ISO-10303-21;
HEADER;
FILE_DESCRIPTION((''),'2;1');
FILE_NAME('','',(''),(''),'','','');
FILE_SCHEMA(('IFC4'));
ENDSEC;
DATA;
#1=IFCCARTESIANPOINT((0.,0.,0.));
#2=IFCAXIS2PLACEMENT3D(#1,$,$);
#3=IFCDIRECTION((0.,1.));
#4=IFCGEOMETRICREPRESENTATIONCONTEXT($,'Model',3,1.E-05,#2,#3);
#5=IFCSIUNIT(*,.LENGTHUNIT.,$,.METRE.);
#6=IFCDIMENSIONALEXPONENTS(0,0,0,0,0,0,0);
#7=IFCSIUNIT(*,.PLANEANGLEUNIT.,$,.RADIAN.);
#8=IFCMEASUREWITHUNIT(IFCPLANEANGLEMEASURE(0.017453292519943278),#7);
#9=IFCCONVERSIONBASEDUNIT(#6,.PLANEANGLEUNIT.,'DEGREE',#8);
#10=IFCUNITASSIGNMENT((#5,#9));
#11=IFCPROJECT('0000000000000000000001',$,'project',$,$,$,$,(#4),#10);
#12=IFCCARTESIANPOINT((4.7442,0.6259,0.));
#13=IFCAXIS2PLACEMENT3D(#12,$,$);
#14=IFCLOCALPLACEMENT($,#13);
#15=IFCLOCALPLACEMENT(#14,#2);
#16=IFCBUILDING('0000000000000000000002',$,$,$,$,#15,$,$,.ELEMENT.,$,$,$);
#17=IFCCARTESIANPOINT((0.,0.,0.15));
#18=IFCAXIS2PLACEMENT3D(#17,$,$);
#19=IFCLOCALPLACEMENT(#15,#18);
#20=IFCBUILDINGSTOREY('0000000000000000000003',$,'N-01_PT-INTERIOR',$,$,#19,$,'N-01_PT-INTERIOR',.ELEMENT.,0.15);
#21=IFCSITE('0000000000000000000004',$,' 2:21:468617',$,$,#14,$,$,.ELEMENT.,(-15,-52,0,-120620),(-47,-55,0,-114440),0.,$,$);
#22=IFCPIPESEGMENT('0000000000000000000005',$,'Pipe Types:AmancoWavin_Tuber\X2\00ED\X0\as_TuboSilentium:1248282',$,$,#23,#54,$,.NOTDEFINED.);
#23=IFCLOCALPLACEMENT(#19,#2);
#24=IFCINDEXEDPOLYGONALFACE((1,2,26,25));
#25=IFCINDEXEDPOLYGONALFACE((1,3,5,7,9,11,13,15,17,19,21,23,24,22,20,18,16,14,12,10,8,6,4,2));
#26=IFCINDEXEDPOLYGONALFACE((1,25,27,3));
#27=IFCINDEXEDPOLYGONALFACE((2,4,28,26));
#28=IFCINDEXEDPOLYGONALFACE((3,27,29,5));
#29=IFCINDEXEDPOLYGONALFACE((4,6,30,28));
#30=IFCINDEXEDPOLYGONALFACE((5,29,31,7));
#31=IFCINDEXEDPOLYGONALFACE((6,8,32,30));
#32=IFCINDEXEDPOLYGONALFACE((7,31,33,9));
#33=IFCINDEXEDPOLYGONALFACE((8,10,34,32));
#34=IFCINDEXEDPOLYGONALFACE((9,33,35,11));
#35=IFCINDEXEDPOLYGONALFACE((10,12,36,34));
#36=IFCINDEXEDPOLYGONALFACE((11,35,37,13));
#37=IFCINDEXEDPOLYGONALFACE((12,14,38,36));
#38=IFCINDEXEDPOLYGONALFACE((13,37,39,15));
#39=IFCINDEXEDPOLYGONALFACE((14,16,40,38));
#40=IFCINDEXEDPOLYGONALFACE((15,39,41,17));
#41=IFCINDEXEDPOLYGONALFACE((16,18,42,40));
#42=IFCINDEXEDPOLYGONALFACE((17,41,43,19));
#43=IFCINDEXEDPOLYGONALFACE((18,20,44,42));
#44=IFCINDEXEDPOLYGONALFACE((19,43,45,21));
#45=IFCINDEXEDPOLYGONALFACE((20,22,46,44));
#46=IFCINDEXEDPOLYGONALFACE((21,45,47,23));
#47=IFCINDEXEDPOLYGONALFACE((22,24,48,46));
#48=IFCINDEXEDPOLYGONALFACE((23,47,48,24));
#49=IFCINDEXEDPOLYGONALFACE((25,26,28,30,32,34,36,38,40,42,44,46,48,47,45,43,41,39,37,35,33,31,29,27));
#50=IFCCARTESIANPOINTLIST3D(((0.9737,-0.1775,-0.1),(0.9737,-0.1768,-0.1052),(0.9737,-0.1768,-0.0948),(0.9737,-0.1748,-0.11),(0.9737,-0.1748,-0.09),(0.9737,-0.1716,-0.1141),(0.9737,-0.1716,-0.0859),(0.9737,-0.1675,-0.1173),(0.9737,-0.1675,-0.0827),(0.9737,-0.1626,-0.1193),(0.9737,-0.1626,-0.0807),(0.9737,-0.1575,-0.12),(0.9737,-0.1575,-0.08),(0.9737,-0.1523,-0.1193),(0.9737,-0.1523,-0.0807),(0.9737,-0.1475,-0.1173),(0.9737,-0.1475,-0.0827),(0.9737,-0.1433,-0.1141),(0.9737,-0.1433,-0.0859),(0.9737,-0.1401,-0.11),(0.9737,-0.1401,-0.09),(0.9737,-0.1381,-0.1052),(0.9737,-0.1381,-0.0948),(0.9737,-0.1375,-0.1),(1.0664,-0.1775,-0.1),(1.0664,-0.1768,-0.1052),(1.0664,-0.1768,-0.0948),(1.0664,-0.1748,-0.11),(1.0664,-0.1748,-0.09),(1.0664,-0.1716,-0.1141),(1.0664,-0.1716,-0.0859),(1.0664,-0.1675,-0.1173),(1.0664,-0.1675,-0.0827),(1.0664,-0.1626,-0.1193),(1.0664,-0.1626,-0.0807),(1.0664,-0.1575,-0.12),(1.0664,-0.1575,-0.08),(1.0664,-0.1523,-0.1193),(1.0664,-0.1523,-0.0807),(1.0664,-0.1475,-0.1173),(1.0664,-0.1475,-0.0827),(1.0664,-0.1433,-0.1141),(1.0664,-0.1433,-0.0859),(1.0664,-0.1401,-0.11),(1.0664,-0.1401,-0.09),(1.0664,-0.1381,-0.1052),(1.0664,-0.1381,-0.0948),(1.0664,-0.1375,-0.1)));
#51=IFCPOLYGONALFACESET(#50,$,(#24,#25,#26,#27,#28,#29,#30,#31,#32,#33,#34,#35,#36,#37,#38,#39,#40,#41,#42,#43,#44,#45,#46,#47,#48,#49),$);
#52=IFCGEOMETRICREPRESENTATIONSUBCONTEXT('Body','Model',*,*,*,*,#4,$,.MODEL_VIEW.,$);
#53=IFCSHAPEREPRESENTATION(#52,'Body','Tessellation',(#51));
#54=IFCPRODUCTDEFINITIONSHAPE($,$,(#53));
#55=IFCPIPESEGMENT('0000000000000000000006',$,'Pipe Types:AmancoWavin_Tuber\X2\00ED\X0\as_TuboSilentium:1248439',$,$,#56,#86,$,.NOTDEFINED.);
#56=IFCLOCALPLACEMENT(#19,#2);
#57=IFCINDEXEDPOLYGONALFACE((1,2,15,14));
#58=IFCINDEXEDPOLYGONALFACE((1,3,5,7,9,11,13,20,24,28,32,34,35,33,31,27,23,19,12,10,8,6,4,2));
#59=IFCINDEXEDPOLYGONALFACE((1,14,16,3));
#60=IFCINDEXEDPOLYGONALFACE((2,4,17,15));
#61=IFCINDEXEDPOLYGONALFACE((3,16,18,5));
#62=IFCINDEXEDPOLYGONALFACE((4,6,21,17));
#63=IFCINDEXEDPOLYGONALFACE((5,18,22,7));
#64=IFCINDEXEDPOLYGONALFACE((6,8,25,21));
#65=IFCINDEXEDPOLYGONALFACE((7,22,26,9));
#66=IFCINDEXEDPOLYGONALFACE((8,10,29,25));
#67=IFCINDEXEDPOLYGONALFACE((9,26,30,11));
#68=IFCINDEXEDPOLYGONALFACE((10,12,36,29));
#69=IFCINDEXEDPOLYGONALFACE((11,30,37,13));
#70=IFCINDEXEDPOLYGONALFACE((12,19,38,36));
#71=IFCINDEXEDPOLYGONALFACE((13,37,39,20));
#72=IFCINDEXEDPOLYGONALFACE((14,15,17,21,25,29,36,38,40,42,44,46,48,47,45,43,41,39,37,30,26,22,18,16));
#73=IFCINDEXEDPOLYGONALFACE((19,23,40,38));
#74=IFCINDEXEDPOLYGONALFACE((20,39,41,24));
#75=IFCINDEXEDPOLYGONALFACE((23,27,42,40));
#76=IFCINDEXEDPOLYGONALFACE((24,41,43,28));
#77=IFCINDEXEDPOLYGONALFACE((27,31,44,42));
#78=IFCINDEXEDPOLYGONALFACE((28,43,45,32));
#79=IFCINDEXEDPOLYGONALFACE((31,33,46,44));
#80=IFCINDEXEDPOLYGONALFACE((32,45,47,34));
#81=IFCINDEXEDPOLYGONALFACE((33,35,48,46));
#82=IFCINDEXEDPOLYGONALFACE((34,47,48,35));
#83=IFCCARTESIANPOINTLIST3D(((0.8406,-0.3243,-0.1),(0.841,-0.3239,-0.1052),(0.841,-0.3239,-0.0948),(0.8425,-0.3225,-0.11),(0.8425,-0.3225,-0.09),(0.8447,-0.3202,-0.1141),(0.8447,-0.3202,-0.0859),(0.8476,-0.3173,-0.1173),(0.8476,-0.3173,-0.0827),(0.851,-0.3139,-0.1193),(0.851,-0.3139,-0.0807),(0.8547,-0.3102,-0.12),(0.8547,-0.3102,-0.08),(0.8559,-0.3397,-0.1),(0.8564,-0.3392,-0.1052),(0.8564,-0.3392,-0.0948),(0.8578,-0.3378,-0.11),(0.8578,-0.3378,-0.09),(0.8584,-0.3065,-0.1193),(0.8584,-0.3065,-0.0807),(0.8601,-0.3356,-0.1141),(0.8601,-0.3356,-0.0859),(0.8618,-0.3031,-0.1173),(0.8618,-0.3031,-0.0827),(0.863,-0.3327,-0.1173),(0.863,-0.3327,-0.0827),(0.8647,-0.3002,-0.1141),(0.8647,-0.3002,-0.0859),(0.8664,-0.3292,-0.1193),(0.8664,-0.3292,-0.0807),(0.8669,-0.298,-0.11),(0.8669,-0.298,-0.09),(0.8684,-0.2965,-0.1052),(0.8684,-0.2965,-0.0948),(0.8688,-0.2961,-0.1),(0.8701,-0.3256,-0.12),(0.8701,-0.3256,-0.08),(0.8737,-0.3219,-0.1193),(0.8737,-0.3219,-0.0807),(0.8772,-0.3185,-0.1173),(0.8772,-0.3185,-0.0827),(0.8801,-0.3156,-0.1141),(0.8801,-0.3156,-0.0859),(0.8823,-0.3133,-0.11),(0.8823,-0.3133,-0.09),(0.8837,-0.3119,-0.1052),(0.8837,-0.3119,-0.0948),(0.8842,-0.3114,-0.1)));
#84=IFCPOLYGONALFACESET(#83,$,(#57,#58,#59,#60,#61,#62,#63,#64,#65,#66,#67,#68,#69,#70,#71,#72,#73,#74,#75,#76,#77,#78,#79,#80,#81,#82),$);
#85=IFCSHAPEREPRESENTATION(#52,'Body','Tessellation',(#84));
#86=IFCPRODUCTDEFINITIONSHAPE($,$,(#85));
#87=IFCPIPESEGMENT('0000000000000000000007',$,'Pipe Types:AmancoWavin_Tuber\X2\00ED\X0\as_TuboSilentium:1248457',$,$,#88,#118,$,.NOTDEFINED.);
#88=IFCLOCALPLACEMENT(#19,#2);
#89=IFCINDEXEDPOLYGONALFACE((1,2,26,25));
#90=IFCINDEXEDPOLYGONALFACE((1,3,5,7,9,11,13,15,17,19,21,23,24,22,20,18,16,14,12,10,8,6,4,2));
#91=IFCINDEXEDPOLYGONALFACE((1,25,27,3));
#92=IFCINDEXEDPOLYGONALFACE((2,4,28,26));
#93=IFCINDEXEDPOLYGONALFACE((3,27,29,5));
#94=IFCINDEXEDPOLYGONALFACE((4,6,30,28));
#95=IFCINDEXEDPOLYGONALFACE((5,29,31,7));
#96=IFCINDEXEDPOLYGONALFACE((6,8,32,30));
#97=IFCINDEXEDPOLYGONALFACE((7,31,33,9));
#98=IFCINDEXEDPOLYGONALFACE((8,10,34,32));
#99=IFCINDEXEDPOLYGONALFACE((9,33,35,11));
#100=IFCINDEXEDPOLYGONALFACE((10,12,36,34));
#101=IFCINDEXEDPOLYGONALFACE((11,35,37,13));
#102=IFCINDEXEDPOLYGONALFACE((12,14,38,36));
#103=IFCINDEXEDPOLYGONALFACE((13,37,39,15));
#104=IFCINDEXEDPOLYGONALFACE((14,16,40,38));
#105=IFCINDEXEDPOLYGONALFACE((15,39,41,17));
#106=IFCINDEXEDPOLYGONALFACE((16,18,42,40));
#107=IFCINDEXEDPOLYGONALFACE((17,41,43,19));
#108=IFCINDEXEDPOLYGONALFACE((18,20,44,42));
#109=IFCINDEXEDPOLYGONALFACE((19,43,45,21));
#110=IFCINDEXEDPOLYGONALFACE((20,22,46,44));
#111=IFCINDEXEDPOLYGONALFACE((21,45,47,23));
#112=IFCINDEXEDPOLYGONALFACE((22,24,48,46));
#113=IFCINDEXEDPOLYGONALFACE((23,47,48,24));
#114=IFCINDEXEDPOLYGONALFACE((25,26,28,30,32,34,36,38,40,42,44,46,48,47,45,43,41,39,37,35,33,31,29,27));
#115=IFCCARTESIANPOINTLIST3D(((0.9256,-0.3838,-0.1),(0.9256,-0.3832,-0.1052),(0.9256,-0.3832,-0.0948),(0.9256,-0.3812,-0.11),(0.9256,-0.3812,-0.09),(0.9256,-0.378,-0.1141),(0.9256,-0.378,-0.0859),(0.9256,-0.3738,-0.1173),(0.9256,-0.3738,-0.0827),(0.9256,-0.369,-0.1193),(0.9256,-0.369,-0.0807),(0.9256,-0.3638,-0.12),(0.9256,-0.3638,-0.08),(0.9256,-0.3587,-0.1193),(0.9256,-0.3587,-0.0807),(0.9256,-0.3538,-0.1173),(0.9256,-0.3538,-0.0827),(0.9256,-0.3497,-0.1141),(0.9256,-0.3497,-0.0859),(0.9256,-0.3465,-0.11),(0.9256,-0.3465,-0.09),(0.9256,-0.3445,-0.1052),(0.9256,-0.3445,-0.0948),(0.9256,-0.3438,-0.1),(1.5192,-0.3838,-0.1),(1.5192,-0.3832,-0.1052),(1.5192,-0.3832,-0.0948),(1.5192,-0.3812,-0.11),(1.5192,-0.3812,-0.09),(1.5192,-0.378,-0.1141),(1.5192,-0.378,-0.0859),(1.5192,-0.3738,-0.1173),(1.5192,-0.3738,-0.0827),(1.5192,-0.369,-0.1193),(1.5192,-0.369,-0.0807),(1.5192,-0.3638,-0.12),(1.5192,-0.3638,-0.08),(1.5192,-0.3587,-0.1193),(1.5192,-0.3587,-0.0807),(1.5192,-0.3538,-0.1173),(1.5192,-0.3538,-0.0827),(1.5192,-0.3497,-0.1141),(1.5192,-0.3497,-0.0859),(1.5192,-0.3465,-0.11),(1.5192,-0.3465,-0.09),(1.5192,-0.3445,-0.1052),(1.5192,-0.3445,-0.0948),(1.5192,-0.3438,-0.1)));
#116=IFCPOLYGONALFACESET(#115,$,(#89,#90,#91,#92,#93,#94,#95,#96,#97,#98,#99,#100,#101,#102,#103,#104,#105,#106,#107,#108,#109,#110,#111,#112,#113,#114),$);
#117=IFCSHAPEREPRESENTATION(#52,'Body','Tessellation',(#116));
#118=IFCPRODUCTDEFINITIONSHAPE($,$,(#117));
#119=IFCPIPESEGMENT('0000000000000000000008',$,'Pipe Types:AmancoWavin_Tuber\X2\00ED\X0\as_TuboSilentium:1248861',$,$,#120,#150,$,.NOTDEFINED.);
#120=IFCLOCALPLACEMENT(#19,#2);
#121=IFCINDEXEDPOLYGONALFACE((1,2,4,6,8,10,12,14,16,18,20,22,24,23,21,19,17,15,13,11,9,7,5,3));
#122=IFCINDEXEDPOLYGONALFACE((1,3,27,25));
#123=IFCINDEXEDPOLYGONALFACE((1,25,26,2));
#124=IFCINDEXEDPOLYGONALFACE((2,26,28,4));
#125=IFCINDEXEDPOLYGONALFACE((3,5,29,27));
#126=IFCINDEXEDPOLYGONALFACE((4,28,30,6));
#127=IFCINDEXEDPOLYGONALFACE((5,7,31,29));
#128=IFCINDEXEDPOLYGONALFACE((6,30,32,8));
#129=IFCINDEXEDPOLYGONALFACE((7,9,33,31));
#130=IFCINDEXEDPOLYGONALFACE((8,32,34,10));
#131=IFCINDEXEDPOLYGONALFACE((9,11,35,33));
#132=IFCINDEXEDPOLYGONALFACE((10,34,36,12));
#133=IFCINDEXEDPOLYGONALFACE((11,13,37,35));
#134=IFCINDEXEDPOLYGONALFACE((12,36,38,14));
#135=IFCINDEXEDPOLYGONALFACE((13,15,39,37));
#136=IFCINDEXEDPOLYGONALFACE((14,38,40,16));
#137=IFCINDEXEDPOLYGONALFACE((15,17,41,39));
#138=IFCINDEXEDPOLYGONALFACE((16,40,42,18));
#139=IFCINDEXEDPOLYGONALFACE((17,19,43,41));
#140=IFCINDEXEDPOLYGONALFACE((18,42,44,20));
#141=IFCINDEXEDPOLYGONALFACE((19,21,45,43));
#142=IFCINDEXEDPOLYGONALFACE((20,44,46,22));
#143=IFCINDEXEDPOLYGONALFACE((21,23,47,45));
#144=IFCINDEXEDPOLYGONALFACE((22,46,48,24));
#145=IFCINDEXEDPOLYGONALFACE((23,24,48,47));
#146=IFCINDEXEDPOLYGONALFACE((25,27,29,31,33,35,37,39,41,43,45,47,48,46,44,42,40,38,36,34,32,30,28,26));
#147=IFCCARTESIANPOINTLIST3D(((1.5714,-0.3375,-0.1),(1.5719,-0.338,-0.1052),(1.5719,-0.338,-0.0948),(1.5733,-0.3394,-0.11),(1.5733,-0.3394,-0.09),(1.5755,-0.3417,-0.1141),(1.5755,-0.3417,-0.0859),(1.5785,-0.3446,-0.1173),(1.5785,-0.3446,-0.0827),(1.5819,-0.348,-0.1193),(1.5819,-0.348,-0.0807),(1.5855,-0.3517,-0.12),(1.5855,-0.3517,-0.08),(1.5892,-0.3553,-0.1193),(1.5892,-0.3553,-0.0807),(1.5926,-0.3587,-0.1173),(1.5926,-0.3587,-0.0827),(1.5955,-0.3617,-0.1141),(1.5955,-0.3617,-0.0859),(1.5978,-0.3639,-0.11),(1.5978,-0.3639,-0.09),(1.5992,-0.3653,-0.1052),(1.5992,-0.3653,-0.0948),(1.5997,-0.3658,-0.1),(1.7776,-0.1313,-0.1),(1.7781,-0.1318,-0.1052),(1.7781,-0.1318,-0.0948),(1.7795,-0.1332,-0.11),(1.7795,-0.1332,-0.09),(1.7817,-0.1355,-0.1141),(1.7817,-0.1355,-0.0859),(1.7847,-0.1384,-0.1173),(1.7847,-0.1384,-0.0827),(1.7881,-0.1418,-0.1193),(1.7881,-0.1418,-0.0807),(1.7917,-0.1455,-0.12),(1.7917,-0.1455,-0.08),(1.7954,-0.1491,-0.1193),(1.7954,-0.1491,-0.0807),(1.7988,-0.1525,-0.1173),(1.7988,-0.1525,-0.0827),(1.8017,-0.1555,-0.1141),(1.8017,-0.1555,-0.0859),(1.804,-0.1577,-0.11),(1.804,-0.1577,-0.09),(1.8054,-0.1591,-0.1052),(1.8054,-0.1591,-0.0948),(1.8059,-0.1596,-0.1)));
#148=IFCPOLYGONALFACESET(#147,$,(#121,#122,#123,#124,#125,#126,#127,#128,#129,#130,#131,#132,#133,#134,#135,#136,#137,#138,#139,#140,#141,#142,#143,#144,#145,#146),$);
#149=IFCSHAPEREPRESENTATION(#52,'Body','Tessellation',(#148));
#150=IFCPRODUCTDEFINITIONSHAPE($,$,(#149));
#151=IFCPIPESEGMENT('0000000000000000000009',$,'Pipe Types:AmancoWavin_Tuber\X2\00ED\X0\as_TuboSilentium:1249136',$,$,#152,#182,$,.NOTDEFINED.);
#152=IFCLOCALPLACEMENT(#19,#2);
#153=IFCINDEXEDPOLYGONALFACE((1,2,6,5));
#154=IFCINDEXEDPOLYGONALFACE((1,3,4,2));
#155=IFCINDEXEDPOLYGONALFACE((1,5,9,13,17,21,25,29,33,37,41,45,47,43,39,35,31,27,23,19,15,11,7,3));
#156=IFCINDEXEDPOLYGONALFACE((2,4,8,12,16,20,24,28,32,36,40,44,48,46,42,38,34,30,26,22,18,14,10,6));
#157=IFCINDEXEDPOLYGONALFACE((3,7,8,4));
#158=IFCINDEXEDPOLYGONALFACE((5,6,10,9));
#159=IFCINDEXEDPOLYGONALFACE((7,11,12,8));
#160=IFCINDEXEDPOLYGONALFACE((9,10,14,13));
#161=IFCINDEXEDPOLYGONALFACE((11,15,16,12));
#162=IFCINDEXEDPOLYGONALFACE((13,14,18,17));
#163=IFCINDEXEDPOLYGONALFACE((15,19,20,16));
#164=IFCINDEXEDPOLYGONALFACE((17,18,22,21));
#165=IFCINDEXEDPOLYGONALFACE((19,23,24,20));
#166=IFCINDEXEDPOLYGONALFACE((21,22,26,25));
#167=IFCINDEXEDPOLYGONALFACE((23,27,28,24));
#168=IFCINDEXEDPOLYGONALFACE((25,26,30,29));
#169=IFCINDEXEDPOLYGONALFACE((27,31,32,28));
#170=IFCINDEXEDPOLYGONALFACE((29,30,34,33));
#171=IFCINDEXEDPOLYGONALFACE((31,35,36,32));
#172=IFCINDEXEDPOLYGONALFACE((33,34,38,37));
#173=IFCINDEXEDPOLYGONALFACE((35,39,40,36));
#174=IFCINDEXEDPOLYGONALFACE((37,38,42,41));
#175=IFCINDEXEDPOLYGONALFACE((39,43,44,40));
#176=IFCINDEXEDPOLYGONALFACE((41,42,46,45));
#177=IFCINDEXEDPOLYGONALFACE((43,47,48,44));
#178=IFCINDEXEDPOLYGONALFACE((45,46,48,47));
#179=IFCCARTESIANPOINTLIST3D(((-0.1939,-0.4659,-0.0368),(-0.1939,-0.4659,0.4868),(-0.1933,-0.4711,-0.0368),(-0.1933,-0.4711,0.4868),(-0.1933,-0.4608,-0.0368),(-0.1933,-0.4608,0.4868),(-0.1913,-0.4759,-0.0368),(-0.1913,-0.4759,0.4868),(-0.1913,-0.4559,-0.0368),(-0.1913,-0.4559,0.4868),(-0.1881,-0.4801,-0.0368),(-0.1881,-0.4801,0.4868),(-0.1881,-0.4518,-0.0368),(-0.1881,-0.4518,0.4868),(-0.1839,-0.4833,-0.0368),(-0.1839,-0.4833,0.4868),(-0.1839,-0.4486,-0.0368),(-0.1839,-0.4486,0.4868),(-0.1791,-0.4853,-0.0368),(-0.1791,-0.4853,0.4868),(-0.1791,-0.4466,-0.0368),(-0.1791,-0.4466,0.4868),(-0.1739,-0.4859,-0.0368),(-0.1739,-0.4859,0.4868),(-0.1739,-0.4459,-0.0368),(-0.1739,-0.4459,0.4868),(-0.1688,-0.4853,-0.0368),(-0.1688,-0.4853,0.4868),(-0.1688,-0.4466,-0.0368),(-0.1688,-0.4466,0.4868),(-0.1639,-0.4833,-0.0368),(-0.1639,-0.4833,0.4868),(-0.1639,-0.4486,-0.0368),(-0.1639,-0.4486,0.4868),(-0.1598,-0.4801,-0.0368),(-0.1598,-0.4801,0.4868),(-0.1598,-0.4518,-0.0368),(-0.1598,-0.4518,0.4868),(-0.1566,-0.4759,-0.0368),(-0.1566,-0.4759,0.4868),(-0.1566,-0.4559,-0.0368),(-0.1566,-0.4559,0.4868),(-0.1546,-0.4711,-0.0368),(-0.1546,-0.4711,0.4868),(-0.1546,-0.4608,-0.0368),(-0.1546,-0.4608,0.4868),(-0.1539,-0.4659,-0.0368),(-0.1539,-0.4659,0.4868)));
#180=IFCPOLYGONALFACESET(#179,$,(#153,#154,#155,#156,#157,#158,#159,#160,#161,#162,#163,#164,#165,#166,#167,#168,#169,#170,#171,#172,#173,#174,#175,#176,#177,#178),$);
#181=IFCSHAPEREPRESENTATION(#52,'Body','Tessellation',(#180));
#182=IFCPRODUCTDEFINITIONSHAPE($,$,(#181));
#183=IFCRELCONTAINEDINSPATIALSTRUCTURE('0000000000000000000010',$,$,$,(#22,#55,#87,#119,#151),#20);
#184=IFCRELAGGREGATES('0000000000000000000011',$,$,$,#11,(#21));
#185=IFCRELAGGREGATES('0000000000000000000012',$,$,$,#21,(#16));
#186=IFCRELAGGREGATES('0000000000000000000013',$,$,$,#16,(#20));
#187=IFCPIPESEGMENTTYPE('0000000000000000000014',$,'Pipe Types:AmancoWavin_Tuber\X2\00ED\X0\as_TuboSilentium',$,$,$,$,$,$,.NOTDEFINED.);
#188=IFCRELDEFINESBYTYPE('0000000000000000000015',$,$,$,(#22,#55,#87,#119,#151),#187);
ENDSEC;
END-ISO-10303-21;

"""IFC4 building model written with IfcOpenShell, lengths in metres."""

from ifc_helpers import new_model, entity, si_unit, converted_unit, direction, frame, origin, place, context, subcontext, project, spatial, arc, indexed_curve, outline, extrude, type_object, element, save


model = new_model("IFC4")

# Units and contexts
model_context = context("Model", 3, precision=1e-05, world=origin(), true_north=direction((0.0, 1.0)))
body_context = subcontext(model_context, "Body", "Model", "MODEL_VIEW")
ifc_project = project(units=[si_unit("LENGTHUNIT", "METRE"), converted_unit("PLANEANGLEUNIT", "DEGREE", entity("IfcPlaneAngleMeasure", 0.017453292519943278), si_unit("PLANEANGLEUNIT", "RADIAN"), dimensions=[0, 0, 0, 0, 0, 0, 0])], contexts=[model_context])

# Site, building, storey
site_placement = place(None, frame((4.7442, 0.6259, 0.0)))
site = spatial("IfcSite", under=ifc_project, at=site_placement, Name=" 2:21:468617", CompositionType="ELEMENT", RefLatitude=(-15, -52, 0, -120620), RefLongitude=(-47, -55, 0, -114440), RefElevation=0.0)
building_placement = place(site_placement, origin())
building = spatial("IfcBuilding", under=site, at=building_placement, CompositionType="ELEMENT")
storey_placement = place(building_placement, frame((0.0, 0.0, 0.15)))
storey = spatial("IfcBuildingStorey", under=building, at=storey_placement, Name="N-01_PT-INTERIOR", LongName="N-01_PT-INTERIOR", CompositionType="ELEMENT", Elevation=0.15)

# Pipe segments
pipe_segment_type_1 = type_object("IfcPipeSegmentType", Name="Pipe Types:AmancoWavin_Tuberías_TuboSilentium", PredefinedType="NOTDEFINED")
pipe_segment_1_placement = place(storey_placement, origin())
element("IfcPipeSegment", 1, at=pipe_segment_1_placement, inside=storey, type_object=pipe_segment_type_1, Name="Pipe Types:AmancoWavin_Tuberías_TuboSilentium:1248282", PredefinedType="NOTDEFINED", context=body_context, shape_type="SweptSolid", body=[
    extrude(outline(indexed_curve([(0.02, 0.0), (0.0141, 0.0141), (0.0, 0.02), (-0.0141, 0.0141), (-0.02, 0.0), (-0.0141, -0.0141), (0.0, -0.02), (0.0141, -0.0141)], segments=[arc(1, 2, 3), arc(3, 4, 5), arc(5, 6, 7), arc(7, 8, 1)], self_intersect=False)), frame((0.9737, -0.1575, -0.1), z_axis=(1.0, 0.0, 0.0), x_axis=(0.0, -1.0, 0.0)), (0.0, 0.0, 1.0), 0.0927),
])
pipe_segment_2_placement = place(storey_placement, origin())
element("IfcPipeSegment", 2, at=pipe_segment_2_placement, inside=storey, type_object=pipe_segment_type_1, Name="Pipe Types:AmancoWavin_Tuberías_TuboSilentium:1248439", PredefinedType="NOTDEFINED", context=body_context, shape_type="SweptSolid", body=[
    extrude(outline(indexed_curve([(0.02, 0.0), (0.0141, 0.0141), (0.0, 0.02), (-0.0141, 0.0141), (-0.02, 0.0), (-0.0141, -0.0141), (0.0, -0.02), (0.0141, -0.0141)], segments=[arc(1, 2, 3), arc(3, 4, 5), arc(5, 6, 7), arc(7, 8, 1)], self_intersect=False)), frame((0.8701, -0.3256, -0.1), z_axis=(-0.707107, 0.707107, 0.0), x_axis=(-0.707107, -0.707107, 0.0)), (0.0, 0.0, 1.0), 0.0218),
])
pipe_segment_3_placement = place(storey_placement, origin())
element("IfcPipeSegment", 3, at=pipe_segment_3_placement, inside=storey, type_object=pipe_segment_type_1, Name="Pipe Types:AmancoWavin_Tuberías_TuboSilentium:1248457", PredefinedType="NOTDEFINED", context=body_context, shape_type="SweptSolid", body=[
    extrude(outline(indexed_curve([(0.02, 0.0), (0.0141, 0.0141), (0.0, 0.02), (-0.0141, 0.0141), (-0.02, 0.0), (-0.0141, -0.0141), (0.0, -0.02), (0.0141, -0.0141)], segments=[arc(1, 2, 3), arc(3, 4, 5), arc(5, 6, 7), arc(7, 8, 1)], self_intersect=False)), frame((0.9256, -0.3638, -0.1), z_axis=(1.0, 0.0, 0.0), x_axis=(0.0, -1.0, 0.0)), (0.0, 0.0, 1.0), 0.5937),
])
pipe_segment_4_placement = place(storey_placement, origin())
element("IfcPipeSegment", 4, at=pipe_segment_4_placement, inside=storey, type_object=pipe_segment_type_1, Name="Pipe Types:AmancoWavin_Tuberías_TuboSilentium:1248861", PredefinedType="NOTDEFINED", context=body_context, shape_type="SweptSolid", body=[
    extrude(outline(indexed_curve([(0.02, 0.0), (0.0141, 0.0141), (0.0, 0.02), (-0.0141, 0.0141), (-0.02, 0.0), (-0.0141, -0.0141), (0.0, -0.02), (0.0141, -0.0141)], segments=[arc(1, 2, 3), arc(3, 4, 5), arc(5, 6, 7), arc(7, 8, 1)], self_intersect=False)), frame((1.5855, -0.3517, -0.1), z_axis=(0.707107, 0.707107, 0.0), x_axis=(0.707107, -0.707107, 0.0)), (0.0, 0.0, 1.0), 0.2916),
])
pipe_segment_5_placement = place(storey_placement, origin())
element("IfcPipeSegment", 5, at=pipe_segment_5_placement, inside=storey, type_object=pipe_segment_type_1, Name="Pipe Types:AmancoWavin_Tuberías_TuboSilentium:1249136", PredefinedType="NOTDEFINED", context=body_context, shape_type="SweptSolid", body=[
    extrude(outline(indexed_curve([(0.02, 0.0), (0.0141, 0.0141), (0.0, 0.02), (-0.0141, 0.0141), (-0.02, 0.0), (-0.0141, -0.0141), (0.0, -0.02), (0.0141, -0.0141)], segments=[arc(1, 2, 3), arc(3, 4, 5), arc(5, 6, 7), arc(7, 8, 1)], self_intersect=False)), frame((-0.1739, -0.4659, -0.0368), z_axis=(0.0, 0.0, 1.0), x_axis=(-1.0, 0.0, 0.0)), (0.0, 0.0, 1.0), 0.5236),
])

save(model, "model.ifc")
